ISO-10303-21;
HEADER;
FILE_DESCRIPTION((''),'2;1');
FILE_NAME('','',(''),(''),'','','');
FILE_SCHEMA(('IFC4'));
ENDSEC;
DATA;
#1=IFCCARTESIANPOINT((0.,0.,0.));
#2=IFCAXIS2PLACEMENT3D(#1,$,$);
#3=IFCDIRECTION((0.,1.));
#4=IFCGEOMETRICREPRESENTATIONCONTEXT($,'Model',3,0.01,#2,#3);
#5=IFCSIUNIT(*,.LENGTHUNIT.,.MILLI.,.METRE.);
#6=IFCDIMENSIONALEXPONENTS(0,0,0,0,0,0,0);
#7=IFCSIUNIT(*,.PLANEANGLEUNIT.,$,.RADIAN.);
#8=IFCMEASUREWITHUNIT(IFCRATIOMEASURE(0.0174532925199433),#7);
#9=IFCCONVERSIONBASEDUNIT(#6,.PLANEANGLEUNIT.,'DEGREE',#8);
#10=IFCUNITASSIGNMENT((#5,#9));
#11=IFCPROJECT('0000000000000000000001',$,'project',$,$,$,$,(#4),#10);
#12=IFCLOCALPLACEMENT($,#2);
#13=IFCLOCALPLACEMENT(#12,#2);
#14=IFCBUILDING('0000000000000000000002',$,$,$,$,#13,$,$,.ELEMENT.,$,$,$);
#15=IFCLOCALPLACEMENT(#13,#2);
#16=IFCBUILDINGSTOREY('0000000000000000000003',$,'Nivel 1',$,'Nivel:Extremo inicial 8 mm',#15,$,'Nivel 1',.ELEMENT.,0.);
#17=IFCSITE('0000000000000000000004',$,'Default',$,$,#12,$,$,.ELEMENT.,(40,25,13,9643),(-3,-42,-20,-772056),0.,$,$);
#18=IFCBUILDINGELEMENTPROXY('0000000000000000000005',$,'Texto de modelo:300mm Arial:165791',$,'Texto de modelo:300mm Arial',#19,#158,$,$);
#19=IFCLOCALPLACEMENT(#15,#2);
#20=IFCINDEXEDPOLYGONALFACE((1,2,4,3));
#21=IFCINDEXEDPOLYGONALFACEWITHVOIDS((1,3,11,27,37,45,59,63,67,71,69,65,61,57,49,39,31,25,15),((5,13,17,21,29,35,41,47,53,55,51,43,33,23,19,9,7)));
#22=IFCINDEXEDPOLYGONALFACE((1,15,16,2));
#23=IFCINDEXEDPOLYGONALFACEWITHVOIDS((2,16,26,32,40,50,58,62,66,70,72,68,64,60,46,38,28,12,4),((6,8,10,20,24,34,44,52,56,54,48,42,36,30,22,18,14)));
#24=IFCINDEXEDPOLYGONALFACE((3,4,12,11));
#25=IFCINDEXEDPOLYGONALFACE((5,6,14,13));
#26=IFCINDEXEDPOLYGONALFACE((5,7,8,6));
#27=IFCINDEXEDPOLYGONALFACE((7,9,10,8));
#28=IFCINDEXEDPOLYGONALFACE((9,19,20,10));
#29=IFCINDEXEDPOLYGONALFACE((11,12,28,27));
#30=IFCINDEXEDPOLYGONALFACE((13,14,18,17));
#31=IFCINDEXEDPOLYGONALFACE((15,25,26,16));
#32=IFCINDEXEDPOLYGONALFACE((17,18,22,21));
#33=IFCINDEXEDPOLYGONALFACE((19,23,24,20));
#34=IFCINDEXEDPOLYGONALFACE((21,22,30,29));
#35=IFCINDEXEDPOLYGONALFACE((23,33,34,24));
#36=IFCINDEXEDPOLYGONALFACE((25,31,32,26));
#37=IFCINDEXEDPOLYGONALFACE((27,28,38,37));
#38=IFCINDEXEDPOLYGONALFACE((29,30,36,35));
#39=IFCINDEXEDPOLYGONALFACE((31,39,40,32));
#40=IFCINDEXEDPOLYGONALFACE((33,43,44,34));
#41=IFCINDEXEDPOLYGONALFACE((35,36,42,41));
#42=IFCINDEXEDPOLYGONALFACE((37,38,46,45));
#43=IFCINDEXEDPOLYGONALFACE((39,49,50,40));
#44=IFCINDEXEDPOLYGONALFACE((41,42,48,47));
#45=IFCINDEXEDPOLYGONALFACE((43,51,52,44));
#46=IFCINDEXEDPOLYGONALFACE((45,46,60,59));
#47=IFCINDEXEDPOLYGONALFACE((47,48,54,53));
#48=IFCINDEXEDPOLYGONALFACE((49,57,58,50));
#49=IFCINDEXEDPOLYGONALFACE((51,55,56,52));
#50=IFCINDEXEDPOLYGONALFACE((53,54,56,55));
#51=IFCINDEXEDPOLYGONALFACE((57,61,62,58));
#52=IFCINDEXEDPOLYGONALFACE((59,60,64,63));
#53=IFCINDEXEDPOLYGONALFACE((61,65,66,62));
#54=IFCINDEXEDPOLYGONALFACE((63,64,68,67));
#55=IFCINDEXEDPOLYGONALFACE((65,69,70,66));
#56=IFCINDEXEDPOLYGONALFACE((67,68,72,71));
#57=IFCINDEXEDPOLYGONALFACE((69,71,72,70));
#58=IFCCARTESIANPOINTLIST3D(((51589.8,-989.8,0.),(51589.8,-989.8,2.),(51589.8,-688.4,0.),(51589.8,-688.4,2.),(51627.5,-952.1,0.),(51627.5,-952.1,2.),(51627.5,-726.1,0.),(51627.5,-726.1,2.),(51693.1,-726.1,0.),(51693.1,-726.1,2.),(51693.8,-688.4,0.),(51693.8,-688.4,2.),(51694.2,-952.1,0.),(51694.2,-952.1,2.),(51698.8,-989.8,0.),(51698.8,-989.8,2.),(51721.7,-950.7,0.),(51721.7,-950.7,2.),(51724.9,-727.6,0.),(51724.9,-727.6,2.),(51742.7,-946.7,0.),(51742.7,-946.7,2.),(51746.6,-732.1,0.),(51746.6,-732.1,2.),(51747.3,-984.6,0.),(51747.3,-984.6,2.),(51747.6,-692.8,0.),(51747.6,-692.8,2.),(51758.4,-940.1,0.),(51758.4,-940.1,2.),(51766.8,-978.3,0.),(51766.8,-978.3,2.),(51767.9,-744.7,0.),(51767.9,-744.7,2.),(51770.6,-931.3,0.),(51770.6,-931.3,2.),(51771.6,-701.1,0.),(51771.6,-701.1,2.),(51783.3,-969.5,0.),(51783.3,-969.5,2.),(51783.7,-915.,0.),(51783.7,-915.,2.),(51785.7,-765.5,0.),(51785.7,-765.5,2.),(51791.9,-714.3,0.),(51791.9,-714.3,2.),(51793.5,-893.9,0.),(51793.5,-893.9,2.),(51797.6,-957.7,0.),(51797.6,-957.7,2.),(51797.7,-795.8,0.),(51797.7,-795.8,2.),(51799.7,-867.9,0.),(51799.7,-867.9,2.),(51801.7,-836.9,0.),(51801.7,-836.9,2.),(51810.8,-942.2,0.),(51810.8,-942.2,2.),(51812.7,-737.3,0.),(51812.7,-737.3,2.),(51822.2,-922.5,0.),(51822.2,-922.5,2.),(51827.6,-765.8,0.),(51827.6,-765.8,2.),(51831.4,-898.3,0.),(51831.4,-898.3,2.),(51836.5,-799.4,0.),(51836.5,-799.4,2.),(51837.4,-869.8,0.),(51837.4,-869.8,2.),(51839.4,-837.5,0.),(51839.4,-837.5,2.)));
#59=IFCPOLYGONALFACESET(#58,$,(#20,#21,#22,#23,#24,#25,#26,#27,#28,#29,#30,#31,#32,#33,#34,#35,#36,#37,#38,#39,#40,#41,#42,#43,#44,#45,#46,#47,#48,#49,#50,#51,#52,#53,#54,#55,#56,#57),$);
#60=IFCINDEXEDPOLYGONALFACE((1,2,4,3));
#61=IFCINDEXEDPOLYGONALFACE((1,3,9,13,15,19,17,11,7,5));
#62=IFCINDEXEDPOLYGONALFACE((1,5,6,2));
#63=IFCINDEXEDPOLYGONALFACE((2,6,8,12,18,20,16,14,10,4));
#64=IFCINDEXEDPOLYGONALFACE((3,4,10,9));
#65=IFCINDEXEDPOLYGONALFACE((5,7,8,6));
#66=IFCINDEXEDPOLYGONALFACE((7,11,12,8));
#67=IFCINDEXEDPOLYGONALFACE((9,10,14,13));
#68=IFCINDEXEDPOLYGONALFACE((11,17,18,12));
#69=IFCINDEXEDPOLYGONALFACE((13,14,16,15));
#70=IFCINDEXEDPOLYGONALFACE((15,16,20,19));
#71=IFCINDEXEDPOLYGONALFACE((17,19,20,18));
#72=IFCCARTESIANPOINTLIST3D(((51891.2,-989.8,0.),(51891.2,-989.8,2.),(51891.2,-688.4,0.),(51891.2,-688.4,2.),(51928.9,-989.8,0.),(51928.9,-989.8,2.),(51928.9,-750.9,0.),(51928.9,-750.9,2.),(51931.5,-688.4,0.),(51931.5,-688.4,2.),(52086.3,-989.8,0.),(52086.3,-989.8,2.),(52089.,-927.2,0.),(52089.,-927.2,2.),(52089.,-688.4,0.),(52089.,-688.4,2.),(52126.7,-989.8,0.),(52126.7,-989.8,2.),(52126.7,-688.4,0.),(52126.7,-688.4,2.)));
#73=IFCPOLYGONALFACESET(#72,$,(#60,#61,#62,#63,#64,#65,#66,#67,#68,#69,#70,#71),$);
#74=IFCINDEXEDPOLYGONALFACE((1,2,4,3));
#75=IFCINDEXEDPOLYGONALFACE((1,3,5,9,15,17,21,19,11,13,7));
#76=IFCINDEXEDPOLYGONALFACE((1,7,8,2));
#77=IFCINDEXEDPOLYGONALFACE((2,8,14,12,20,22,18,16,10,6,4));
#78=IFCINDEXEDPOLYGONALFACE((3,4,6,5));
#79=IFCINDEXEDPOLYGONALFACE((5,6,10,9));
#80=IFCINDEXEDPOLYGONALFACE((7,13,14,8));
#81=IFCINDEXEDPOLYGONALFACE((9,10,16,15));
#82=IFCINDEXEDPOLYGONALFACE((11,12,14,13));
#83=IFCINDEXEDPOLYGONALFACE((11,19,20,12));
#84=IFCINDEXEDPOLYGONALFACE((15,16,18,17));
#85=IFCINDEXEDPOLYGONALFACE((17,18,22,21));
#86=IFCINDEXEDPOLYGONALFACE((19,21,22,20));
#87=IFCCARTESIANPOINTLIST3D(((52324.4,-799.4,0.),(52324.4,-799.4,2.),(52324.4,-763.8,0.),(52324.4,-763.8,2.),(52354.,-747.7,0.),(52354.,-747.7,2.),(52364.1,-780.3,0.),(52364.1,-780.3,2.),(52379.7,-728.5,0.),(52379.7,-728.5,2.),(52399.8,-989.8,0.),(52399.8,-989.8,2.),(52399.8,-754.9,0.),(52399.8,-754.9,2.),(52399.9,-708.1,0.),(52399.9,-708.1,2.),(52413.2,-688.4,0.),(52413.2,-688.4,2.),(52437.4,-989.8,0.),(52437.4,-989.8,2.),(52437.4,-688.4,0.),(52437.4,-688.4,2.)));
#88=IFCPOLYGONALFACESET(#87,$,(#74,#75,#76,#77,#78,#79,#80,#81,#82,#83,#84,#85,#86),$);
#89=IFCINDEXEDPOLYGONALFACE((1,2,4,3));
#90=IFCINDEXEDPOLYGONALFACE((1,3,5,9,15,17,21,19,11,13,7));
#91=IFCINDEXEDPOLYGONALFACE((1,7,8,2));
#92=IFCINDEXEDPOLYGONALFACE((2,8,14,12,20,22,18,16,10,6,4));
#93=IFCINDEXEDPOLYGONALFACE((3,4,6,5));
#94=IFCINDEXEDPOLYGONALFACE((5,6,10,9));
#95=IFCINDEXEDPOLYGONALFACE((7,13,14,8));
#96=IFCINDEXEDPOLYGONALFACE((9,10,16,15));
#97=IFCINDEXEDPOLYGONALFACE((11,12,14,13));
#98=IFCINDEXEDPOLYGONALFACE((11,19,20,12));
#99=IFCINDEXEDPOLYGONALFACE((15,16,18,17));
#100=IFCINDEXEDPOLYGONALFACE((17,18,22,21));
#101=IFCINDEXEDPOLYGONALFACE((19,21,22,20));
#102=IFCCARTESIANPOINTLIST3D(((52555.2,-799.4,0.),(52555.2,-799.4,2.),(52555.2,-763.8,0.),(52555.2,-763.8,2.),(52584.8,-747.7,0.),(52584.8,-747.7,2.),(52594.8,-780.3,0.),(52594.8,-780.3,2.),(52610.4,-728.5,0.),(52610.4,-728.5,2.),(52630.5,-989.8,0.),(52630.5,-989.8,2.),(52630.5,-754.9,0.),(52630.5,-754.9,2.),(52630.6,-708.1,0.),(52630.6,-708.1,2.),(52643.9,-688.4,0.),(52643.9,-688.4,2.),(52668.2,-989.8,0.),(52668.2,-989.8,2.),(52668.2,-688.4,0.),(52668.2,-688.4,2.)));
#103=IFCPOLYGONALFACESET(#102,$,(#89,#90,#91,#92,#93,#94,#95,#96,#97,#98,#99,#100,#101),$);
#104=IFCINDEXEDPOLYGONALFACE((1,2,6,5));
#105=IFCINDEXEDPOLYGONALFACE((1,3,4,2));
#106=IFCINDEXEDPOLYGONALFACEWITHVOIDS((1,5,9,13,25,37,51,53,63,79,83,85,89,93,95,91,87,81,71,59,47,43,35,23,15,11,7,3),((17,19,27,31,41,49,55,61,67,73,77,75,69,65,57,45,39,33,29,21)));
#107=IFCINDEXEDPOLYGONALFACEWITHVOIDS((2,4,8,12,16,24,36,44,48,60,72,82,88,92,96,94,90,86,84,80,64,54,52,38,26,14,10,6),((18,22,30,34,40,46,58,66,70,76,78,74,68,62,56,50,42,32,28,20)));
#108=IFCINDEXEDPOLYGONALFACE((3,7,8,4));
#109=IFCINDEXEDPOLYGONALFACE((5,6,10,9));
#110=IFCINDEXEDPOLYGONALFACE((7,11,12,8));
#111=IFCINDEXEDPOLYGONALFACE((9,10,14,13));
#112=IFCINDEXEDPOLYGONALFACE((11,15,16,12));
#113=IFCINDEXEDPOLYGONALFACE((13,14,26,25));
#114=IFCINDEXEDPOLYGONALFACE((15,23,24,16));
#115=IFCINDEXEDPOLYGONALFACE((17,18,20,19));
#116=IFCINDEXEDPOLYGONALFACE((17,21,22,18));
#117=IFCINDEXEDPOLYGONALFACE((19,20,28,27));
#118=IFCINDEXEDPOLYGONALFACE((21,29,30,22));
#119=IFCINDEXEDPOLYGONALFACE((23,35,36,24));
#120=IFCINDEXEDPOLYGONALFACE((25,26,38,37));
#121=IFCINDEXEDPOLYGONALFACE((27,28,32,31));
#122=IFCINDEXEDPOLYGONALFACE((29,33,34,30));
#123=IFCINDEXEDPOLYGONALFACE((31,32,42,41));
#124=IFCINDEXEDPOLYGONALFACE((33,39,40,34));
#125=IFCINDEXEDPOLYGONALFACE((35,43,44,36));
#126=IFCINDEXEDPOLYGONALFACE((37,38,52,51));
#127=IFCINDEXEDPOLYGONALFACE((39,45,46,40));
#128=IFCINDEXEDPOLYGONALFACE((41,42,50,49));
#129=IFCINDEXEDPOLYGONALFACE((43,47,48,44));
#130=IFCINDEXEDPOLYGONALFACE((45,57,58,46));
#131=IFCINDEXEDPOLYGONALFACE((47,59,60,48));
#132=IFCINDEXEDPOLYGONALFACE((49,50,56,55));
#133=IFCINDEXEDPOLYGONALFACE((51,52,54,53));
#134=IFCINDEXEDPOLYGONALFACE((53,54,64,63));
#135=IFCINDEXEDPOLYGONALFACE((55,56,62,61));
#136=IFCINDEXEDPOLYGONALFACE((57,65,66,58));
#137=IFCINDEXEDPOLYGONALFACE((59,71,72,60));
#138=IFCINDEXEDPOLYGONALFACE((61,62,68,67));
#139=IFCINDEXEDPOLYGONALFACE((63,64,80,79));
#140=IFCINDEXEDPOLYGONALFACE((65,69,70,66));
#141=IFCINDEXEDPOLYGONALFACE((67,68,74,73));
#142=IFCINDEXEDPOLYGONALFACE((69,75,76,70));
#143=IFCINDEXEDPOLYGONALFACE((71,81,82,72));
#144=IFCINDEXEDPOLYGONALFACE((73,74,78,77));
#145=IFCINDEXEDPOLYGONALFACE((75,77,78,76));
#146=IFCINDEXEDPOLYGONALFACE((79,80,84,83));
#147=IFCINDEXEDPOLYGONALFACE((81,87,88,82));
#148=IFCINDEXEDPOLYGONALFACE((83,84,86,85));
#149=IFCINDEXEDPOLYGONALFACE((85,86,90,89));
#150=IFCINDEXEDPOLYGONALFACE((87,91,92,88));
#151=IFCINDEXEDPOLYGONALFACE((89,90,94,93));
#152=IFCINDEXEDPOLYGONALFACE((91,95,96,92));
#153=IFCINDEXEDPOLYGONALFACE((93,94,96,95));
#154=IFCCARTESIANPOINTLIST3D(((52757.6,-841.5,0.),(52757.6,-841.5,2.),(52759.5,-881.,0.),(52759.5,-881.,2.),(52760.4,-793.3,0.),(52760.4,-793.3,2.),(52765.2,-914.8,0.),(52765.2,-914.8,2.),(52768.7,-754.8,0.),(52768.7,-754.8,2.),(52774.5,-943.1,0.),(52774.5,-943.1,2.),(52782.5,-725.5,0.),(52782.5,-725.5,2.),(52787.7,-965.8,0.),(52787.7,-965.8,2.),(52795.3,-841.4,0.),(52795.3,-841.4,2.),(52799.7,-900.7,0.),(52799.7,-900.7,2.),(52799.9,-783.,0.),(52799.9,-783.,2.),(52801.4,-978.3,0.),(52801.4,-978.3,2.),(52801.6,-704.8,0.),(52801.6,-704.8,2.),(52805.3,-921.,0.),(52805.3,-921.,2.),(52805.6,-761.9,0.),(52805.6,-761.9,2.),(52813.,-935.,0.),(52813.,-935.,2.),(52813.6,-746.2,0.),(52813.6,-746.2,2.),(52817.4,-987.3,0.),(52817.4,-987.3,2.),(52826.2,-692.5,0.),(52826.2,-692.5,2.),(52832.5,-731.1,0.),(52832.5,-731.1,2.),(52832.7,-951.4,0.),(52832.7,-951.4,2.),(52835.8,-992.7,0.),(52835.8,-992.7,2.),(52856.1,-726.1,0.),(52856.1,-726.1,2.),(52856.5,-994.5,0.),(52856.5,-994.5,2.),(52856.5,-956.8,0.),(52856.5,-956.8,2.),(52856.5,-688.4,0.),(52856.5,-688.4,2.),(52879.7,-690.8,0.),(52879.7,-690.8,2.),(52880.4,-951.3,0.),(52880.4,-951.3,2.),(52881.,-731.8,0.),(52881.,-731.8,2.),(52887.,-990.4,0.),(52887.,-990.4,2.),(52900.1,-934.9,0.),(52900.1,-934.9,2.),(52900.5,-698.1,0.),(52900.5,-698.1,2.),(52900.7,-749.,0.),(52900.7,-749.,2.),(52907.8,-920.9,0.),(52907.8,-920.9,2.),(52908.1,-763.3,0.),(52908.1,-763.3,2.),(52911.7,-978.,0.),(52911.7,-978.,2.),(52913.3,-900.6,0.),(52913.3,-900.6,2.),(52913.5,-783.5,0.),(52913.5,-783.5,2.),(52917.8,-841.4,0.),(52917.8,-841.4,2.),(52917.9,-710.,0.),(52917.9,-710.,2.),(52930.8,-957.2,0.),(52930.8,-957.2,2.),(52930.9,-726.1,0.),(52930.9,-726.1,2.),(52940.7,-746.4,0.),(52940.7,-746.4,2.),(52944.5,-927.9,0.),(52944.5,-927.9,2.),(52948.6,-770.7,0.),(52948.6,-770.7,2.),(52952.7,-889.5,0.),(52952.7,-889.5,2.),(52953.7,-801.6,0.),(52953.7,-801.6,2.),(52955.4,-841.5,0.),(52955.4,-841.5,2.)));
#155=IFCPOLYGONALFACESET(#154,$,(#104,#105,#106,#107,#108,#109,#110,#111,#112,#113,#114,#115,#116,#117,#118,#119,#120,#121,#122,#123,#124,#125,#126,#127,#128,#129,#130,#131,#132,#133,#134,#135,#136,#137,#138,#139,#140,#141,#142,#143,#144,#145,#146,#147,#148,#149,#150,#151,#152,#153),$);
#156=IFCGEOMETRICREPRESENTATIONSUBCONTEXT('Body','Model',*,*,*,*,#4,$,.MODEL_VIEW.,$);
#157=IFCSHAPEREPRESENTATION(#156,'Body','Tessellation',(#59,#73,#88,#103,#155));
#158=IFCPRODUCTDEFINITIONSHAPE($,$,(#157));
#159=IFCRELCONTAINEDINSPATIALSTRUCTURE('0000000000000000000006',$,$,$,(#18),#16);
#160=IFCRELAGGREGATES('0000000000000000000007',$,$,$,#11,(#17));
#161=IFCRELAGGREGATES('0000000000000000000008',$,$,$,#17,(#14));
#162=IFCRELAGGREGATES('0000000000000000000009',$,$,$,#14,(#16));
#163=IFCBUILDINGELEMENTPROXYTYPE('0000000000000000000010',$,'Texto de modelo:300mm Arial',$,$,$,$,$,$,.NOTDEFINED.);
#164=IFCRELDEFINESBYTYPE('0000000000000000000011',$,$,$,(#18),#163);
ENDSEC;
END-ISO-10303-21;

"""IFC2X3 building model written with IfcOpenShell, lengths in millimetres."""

from ifc_helpers import new_model, entity, si_unit, converted_unit, direction, frame, origin, place, context, subcontext, project, spatial, polyline, outline, extrude, type_object, element, save


model = new_model("IFC2X3")

# Units and contexts
model_context = context("Model", 3, precision=0.01, world=origin(), true_north=direction((0.0, 1.0)))
body_context = subcontext(model_context, "Body", "Model", "MODEL_VIEW")
ifc_project = project(units=[si_unit("LENGTHUNIT", "METRE", prefix="MILLI"), converted_unit("PLANEANGLEUNIT", "DEGREE", entity("IfcRatioMeasure", 0.0174532925199433), si_unit("PLANEANGLEUNIT", "RADIAN"), dimensions=[0, 0, 0, 0, 0, 0, 0])], contexts=[model_context])

# Site, building, storey
site_placement = place(None, origin())
site = spatial("IfcSite", under=ifc_project, at=site_placement, Name="Default", CompositionType="ELEMENT", RefLatitude=(40, 25, 13, 9643), RefLongitude=(-3, -42, -20, -772056), RefElevation=0.0)
building_placement = place(site_placement, origin())
building = spatial("IfcBuilding", under=site, at=building_placement, CompositionType="ELEMENT")
storey_placement = place(building_placement, origin())
storey = spatial("IfcBuildingStorey", under=building, at=storey_placement, Name="Nivel 1", ObjectType="Nivel:Extremo inicial 8 mm", LongName="Nivel 1", CompositionType="ELEMENT", Elevation=0.0)

# Building element proxy
building_element_proxy_type_1 = type_object("IfcBuildingElementProxyType", Name="Texto de modelo:300mm Arial", PredefinedType="NOTDEFINED")
proxy_1_placement = place(storey_placement, frame((51589.8, -994.5, 0.0)))
element("IfcBuildingElementProxy", 1, at=proxy_1_placement, inside=storey, type_object=building_element_proxy_type_1, Name="Texto de modelo:300mm Arial:165791", ObjectType="Texto de modelo:300mm Arial", context=body_context, shape_type="SweptSolid", body=[
    extrude(outline(polyline([(-178.4, -141.0), (-69.4, -141.0), (-21.0, -135.8), (-1.4, -129.5), (15.0, -120.7), (29.4, -108.9), (42.6, -93.4), (54.0, -73.7), (63.2, -49.5), (69.2, -21.0), (71.2, 11.3), (68.2, 49.4), (59.3, 83.0), (44.5, 111.5), (23.7, 134.5), (3.4, 147.7), (-20.6, 156.1), (-74.4, 160.4), (-178.4, 160.4), (-178.4, -141.0)]), holes=[polyline([(-140.7, -103.3), (-140.7, 122.7), (-75.1, 122.7), (-43.3, 121.2), (-21.7, 116.7), (-0.4, 104.1), (17.4, 83.3), (29.5, 53.0), (33.5, 11.9), (31.5, -19.1), (25.3, -45.1), (15.5, -66.2), (2.4, -82.5), (-9.8, -91.3), (-25.6, -97.9), (-46.5, -101.9), (-74.1, -103.3), (-140.7, -103.3)])]), frame((178.4, 145.7, 0.0)), (0.0, 0.0, 1.0), 2.0),
    extrude(outline(polyline([(-117.7, -150.7), (-80.1, -150.7), (-80.1, 88.1), (77.4, -150.7), (117.7, -150.7), (117.7, 150.7), (80.1, 150.7), (80.1, -88.1), (-77.4, 150.7), (-117.7, 150.7), (-117.7, -150.7)])), frame((419.1, 155.4, 0.0)), (0.0, 0.0, 1.0), 2.0),
    extrude(outline(polyline([(-204.4, -52.5), (97.0, -52.5), (97.0, -28.2), (77.2, -14.9), (56.9, 5.3), (37.7, 30.9), (21.6, 60.5), (-14.0, 60.5), (5.0, 20.8), (30.4, -14.9), (-204.4, -14.9), (-204.4, -52.5)])), frame((795.1, 209.1, 0.0), z_axis=(0.0, 0.0, 1.0), x_axis=(0.0, 1.0, 0.0)), (0.0, 0.0, 1.0), 2.0),
    extrude(outline(polyline([(-204.4, -52.5), (97.0, -52.5), (97.0, -28.2), (77.2, -14.9), (56.9, 5.3), (37.7, 30.9), (21.6, 60.5), (-14.0, 60.5), (5.0, 20.8), (30.4, -14.9), (-204.4, -14.9), (-204.4, -52.5)])), frame((1025.8, 209.1, 0.0), z_axis=(0.0, 0.0, 1.0), x_axis=(0.0, 1.0, 0.0)), (0.0, 0.0, 1.0), 2.0),
    extrude(outline(polyline([(-5.6, -99.5), (33.9, -99.5), (68.0, -95.5), (96.7, -87.5), (120.0, -75.5), (133.2, -62.4), (142.9, -46.8), (149.1, -28.7), (151.9, -8.0), (149.2, 22.6), (138.0, 47.8), (118.2, 67.9), (89.5, 82.9), (51.6, 93.0), (3.8, 98.0), (-36.2, 98.2), (-67.3, 94.5), (-91.9, 87.9), (-112.6, 79.0), (-129.4, 66.8), (-142.0, 50.0), (-150.3, 29.6), (-153.8, 6.5), (-151.2, -23.9), (-140.1, -49.1), (-120.3, -69.2), (-91.7, -84.4), (-53.6, -94.5), (-5.6, -99.5)]), holes=[polyline([(-3.9, -61.9), (-62.1, -54.6), (-82.9, -47.9), (-98.1, -39.2), (-112.3, -19.5), (-116.2, 4.3), (-109.3, 28.9), (-91.2, 47.7), (-76.5, 54.5), (-56.1, 58.9), (1.9, 60.4), (60.8, 53.2), (80.8, 46.7), (94.5, 38.3), (109.9, 17.8), (114.3, -6.3), (107.7, -29.8), (90.4, -48.7), (76.0, -55.8), (55.5, -60.3), (-3.9, -61.9)])]), frame((1267.5, 152.1, 0.0), z_axis=(0.0, 0.0, 1.0), x_axis=(0.047515, -0.998871, 0.0)), (0.0, 0.0, 1.0), 2.0),
])

save(model, "model.ifc")
